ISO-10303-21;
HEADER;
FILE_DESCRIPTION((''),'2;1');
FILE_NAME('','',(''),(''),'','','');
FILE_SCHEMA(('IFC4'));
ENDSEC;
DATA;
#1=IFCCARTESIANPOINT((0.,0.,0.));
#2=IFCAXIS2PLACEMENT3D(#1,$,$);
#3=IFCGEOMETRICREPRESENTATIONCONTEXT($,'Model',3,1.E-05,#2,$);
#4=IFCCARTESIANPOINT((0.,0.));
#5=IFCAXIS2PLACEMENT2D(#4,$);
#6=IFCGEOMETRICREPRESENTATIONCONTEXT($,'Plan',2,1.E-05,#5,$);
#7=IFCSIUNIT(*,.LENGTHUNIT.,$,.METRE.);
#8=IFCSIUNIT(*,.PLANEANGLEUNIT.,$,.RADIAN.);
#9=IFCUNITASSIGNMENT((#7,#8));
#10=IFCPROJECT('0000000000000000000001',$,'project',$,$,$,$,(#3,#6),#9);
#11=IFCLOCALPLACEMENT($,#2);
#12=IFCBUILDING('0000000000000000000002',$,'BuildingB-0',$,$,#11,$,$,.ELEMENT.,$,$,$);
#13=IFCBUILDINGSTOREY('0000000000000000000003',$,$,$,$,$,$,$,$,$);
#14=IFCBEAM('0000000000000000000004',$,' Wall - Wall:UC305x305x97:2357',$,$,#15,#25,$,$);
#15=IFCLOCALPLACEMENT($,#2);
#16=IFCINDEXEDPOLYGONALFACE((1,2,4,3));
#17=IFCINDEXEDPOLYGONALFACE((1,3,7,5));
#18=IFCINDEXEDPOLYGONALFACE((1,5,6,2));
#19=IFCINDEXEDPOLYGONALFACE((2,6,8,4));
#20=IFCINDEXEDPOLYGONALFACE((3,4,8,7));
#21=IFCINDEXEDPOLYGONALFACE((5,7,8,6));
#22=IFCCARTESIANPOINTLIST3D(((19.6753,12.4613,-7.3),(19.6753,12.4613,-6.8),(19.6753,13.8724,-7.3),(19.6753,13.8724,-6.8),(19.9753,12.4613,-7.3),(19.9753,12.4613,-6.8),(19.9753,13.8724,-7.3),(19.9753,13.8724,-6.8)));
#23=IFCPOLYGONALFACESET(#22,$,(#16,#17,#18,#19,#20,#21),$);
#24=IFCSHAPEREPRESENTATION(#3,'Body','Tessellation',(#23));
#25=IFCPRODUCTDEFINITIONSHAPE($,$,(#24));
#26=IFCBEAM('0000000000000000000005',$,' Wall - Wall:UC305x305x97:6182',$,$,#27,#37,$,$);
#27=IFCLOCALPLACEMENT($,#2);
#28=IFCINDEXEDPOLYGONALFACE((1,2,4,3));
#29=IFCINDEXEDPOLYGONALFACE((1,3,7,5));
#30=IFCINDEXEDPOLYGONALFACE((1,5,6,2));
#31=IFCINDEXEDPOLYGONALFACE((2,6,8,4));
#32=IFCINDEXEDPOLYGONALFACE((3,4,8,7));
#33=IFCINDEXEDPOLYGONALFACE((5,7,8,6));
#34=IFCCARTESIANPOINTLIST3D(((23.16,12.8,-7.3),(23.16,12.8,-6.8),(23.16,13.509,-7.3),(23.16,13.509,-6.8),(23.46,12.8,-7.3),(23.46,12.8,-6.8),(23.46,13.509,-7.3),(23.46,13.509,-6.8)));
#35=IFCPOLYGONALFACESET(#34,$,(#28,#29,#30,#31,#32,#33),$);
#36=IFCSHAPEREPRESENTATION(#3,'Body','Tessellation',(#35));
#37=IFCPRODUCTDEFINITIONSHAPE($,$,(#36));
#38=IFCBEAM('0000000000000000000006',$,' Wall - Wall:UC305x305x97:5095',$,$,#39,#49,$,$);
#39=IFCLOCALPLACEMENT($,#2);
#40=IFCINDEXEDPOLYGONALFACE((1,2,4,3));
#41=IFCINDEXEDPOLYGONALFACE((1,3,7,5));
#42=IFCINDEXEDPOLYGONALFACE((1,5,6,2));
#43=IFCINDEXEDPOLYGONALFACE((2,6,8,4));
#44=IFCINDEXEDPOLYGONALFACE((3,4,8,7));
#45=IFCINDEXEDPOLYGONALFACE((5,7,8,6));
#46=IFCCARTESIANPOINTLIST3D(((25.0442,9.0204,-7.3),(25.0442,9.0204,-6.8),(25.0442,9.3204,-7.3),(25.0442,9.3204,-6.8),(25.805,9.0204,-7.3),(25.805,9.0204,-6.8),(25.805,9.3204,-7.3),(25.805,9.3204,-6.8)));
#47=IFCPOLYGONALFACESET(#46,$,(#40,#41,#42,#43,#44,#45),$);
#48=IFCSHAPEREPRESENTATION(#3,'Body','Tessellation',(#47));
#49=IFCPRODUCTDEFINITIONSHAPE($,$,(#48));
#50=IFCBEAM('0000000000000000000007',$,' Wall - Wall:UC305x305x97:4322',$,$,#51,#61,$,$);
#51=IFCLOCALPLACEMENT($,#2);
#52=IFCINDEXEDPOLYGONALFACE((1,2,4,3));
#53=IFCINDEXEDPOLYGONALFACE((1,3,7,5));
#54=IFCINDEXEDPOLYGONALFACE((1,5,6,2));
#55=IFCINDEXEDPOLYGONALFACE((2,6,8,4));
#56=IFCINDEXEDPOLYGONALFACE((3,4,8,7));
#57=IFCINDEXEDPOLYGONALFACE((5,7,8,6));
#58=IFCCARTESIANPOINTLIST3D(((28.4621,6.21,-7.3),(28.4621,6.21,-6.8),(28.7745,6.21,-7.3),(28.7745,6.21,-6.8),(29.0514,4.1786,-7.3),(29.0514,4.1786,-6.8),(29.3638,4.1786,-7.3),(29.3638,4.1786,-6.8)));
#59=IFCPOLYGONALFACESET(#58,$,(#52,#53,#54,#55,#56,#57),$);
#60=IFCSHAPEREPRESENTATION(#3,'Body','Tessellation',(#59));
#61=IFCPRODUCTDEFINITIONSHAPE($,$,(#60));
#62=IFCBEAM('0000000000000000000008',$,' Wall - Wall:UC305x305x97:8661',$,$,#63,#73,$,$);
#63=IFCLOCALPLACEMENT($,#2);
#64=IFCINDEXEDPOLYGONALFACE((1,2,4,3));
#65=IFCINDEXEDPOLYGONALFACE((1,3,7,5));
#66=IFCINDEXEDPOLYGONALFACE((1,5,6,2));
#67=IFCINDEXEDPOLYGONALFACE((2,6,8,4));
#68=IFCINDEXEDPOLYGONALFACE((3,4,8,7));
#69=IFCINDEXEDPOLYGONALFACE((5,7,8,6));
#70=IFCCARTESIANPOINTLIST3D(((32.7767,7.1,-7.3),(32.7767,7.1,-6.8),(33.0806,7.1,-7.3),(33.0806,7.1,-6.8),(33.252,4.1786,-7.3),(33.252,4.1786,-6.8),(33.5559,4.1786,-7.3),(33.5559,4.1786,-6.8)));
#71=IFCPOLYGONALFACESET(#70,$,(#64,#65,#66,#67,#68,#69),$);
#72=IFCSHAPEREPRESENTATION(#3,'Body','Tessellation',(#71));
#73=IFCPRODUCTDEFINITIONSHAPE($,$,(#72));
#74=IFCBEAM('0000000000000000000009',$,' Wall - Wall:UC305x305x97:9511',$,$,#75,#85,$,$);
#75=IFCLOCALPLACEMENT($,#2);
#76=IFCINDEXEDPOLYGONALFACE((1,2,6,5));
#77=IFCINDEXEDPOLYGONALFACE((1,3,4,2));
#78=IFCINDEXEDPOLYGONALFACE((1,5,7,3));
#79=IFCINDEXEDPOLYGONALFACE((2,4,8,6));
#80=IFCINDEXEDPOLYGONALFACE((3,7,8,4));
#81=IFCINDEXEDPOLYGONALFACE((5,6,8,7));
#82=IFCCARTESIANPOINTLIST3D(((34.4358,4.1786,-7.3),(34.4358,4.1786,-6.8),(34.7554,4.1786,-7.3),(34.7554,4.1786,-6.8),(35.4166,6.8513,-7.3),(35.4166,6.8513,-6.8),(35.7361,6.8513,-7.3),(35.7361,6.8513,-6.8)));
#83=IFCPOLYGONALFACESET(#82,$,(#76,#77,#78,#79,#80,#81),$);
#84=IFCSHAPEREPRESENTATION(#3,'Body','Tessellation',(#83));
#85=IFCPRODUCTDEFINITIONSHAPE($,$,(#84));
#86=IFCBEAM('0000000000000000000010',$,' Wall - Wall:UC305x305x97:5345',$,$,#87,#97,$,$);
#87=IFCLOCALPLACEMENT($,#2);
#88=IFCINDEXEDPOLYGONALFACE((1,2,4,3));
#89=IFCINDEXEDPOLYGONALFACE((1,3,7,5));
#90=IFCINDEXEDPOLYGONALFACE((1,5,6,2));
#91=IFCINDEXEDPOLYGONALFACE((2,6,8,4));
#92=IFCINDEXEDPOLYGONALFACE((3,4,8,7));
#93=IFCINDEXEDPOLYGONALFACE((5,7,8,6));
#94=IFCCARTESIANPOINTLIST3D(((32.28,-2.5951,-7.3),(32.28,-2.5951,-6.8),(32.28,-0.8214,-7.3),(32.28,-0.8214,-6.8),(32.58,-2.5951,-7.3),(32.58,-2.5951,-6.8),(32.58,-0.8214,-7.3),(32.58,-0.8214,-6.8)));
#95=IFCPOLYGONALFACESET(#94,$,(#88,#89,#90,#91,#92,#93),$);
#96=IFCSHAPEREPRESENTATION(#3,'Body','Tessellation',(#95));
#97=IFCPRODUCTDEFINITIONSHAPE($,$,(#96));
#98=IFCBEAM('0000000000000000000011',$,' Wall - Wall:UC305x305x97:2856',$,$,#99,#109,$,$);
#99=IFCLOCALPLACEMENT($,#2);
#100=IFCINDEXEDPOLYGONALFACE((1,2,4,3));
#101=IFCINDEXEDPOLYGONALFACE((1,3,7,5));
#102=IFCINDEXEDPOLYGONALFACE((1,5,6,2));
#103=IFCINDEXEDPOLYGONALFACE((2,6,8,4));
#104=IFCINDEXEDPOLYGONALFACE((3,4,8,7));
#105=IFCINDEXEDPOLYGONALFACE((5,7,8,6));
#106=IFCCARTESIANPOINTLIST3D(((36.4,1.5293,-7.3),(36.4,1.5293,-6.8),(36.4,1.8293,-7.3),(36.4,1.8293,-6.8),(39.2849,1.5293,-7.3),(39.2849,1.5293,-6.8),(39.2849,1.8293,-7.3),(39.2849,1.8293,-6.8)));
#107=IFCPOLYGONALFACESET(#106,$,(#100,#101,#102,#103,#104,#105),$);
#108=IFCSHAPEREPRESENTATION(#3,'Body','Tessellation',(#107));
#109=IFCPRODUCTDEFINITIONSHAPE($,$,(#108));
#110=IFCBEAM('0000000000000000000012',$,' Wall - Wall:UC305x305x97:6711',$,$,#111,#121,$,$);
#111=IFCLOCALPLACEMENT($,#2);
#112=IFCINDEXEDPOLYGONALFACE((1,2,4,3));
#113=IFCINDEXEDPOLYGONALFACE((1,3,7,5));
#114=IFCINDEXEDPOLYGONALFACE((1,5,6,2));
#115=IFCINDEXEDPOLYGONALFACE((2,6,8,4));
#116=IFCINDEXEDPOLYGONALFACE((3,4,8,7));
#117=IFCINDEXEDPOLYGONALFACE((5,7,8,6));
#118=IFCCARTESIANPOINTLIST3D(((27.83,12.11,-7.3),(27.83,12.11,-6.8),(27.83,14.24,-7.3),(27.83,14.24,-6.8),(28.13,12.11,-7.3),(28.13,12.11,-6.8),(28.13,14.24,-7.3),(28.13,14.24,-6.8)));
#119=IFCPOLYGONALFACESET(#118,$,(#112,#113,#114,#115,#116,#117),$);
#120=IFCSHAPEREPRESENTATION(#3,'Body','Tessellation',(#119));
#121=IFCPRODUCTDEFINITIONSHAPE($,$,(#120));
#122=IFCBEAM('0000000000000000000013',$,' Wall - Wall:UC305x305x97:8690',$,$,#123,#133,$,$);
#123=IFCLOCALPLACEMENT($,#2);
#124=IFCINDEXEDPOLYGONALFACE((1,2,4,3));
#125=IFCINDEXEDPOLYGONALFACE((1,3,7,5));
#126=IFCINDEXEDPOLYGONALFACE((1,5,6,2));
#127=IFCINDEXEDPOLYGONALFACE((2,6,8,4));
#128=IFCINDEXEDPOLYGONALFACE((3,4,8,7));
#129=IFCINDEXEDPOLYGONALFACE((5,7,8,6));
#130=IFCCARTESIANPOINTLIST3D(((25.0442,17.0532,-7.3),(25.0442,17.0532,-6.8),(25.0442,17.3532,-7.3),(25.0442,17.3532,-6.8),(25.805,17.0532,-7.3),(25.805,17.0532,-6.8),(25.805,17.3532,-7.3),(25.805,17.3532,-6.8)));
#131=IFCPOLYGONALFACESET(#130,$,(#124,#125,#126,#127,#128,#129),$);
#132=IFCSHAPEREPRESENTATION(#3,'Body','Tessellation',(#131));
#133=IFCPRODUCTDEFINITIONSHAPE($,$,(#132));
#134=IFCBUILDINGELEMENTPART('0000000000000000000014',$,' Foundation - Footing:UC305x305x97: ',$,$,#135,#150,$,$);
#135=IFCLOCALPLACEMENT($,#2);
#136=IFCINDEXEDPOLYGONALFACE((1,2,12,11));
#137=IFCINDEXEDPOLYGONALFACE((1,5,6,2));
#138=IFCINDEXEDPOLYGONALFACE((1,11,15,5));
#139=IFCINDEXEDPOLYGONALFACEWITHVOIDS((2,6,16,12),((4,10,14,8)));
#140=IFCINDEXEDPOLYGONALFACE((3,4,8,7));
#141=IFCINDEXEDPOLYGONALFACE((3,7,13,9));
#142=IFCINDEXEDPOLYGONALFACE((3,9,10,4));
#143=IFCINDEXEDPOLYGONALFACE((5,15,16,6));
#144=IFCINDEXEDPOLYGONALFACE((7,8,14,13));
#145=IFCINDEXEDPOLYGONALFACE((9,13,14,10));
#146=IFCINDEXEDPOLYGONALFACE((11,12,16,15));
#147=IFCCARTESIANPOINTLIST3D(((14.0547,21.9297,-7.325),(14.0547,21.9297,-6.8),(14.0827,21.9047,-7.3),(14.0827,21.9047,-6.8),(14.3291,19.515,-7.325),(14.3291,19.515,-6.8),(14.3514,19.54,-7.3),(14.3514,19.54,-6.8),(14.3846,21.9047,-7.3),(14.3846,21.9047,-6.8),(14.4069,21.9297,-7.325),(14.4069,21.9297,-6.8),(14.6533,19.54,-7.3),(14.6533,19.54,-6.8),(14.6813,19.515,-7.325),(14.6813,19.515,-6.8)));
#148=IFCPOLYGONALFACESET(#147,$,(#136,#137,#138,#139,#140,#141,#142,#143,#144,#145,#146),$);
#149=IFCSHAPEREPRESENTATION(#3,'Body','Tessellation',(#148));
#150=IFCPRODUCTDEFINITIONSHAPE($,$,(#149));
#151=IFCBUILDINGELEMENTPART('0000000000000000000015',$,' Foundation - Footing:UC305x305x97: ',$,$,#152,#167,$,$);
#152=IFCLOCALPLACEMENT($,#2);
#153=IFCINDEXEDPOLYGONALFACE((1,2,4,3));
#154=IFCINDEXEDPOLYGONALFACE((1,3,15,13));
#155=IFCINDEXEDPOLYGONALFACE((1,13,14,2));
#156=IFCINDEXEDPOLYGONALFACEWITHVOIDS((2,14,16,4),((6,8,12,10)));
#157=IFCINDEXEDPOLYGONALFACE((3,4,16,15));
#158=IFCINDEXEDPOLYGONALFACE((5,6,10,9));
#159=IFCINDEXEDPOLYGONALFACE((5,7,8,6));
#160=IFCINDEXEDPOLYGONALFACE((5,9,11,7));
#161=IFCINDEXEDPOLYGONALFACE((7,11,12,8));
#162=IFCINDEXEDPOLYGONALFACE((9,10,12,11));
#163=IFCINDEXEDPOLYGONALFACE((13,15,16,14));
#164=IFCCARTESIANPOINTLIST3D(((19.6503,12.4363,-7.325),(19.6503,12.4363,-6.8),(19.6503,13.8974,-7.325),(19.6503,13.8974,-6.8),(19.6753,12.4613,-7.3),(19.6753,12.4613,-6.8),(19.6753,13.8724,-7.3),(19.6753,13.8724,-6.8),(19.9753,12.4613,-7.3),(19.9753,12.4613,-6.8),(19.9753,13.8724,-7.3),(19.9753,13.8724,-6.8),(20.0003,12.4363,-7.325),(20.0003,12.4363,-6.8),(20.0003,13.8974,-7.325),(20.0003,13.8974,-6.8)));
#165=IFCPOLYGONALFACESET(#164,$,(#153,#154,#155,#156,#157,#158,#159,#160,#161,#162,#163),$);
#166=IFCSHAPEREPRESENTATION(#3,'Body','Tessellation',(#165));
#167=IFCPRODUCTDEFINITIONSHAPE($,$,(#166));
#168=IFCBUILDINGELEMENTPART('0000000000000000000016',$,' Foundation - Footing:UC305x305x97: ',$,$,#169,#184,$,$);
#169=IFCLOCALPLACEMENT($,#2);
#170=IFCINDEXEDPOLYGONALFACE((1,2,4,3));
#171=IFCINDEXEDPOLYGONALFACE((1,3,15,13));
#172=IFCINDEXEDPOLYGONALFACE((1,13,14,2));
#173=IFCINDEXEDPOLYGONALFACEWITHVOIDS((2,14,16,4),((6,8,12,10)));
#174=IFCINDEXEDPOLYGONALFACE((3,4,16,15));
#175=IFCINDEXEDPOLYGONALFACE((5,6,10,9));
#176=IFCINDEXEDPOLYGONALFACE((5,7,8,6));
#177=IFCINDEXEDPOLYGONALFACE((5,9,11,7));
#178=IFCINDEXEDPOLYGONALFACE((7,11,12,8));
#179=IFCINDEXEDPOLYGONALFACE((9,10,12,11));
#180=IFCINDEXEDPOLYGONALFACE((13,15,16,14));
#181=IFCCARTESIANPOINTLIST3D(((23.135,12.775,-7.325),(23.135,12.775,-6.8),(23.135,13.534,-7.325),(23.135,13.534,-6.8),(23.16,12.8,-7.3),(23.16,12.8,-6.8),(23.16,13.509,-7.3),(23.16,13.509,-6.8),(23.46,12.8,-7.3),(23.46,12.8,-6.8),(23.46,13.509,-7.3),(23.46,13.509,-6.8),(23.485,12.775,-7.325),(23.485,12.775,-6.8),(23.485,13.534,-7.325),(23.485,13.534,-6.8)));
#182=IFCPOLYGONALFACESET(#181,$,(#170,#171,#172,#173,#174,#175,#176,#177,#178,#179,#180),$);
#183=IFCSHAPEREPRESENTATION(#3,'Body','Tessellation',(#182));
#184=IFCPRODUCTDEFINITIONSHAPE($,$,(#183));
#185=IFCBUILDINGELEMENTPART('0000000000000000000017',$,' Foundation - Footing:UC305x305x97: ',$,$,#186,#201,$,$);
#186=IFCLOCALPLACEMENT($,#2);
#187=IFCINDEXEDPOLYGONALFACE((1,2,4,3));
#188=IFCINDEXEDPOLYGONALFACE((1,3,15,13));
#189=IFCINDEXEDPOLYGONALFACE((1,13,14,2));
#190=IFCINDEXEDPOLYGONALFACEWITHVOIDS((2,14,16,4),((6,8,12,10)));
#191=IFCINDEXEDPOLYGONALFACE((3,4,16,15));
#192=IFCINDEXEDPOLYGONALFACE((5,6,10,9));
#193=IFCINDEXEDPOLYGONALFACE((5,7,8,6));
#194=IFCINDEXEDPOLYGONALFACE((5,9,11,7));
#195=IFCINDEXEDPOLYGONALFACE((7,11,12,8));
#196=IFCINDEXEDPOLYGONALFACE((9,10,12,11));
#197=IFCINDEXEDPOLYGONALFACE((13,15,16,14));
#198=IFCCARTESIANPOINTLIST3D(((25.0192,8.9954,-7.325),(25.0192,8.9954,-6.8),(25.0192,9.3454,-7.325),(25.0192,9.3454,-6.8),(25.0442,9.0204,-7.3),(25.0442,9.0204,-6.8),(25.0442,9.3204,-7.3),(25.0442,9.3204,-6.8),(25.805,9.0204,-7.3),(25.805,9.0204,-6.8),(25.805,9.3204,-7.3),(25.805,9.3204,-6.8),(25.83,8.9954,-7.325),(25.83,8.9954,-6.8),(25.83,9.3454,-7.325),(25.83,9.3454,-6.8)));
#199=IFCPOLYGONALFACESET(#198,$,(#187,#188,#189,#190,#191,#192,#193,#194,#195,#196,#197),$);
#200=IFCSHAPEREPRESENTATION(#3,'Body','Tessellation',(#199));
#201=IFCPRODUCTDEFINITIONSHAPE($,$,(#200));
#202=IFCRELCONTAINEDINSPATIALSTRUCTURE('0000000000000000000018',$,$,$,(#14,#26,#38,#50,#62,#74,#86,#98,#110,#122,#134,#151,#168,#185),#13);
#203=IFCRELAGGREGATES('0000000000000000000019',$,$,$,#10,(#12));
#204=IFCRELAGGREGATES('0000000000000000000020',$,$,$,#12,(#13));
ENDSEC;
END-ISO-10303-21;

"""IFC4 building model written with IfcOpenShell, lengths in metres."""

from ifc_helpers import new_model, si_unit, origin, origin_2d, place, context, project, spatial, polyline, outline, extrude, element, save


model = new_model("IFC4")

# Units and contexts
model_context = context("Model", 3, precision=1e-05, world=origin())
plan_context = context("Plan", 2, precision=1e-05, world=origin_2d())
ifc_project = project(units=[si_unit("LENGTHUNIT", "METRE"), si_unit("PLANEANGLEUNIT", "RADIAN")], contexts=[model_context, plan_context])

# Building, storey
building_placement = place(None, origin())
building = spatial("IfcBuilding", under=ifc_project, at=building_placement, Name="BuildingB-0", CompositionType="ELEMENT")
storey = spatial("IfcBuildingStorey", under=building)

# Beams
element("IfcBeam", 1, inside=storey, Name=" Wall - Wall:UC305x305x97:2357", context=model_context, shape_type="SweptSolid", body=[
    extrude(outline(polyline([(19.6753, 12.4613, -7.3), (19.9753, 12.4613, -7.3), (19.9753, 13.8724, -7.3), (19.6753, 13.8724, -7.3), (19.6753, 12.4613, -7.3)])), None, (0.0, 0.0, 1.0), 0.5),
])
element("IfcBeam", 2, inside=storey, Name=" Wall - Wall:UC305x305x97:6182", context=model_context, shape_type="SweptSolid", body=[
    extrude(outline(polyline([(23.16, 12.8, -7.3), (23.46, 12.8, -7.3), (23.46, 13.509, -7.3), (23.16, 13.509, -7.3), (23.16, 12.8, -7.3)])), None, (0.0, 0.0, 1.0), 0.5),
])
element("IfcBeam", 3, inside=storey, Name=" Wall - Wall:UC305x305x97:5095", context=model_context, shape_type="SweptSolid", body=[
    extrude(outline(polyline([(25.0442, 9.0204, -7.3), (25.805, 9.0204, -7.3), (25.805, 9.3204, -7.3), (25.0442, 9.3204, -7.3), (25.0442, 9.0204, -7.3)])), None, (0.0, 0.0, 1.0), 0.5),
])
element("IfcBeam", 4, inside=storey, Name=" Wall - Wall:UC305x305x97:4322", context=model_context, shape_type="SweptSolid", body=[
    extrude(outline(polyline([(29.0514, 4.1786, -7.3), (29.3638, 4.1786, -7.3), (28.7745, 6.21, -7.3), (28.4621, 6.21, -7.3), (29.0514, 4.1786, -7.3)])), None, (0.0, 0.0, 1.0), 0.5),
])
element("IfcBeam", 5, inside=storey, Name=" Wall - Wall:UC305x305x97:8661", context=model_context, shape_type="SweptSolid", body=[
    extrude(outline(polyline([(33.252, 4.1786, -7.3), (33.5559, 4.1786, -7.3), (33.0806, 7.1, -7.3), (32.7767, 7.1, -7.3), (33.252, 4.1786, -7.3)])), None, (0.0, 0.0, 1.0), 0.5),
])
element("IfcBeam", 6, inside=storey, Name=" Wall - Wall:UC305x305x97:9511", context=model_context, shape_type="SweptSolid", body=[
    extrude(outline(polyline([(34.4358, 4.1786, -7.3), (34.7554, 4.1786, -7.3), (35.7361, 6.8513, -7.3), (35.4166, 6.8513, -7.3), (34.4358, 4.1786, -7.3)])), None, (0.0, 0.0, 1.0), 0.5),
])
element("IfcBeam", 7, inside=storey, Name=" Wall - Wall:UC305x305x97:5345", context=model_context, shape_type="SweptSolid", body=[
    extrude(outline(polyline([(32.28, -2.5951, -7.3), (32.58, -2.5951, -7.3), (32.58, -0.8214, -7.3), (32.28, -0.8214, -7.3), (32.28, -2.5951, -7.3)])), None, (0.0, 0.0, 1.0), 0.5),
])
element("IfcBeam", 8, inside=storey, Name=" Wall - Wall:UC305x305x97:2856", context=model_context, shape_type="SweptSolid", body=[
    extrude(outline(polyline([(36.4, 1.5293, -7.3), (36.4, 1.8293, -7.3), (39.2849, 1.8293, -7.3), (39.2849, 1.5293, -7.3), (36.4, 1.5293, -7.3)])), None, (0.0, 0.0, 1.0), 0.5),
])
element("IfcBeam", 9, inside=storey, Name=" Wall - Wall:UC305x305x97:6711", context=model_context, shape_type="SweptSolid", body=[
    extrude(outline(polyline([(27.83, 12.11, -7.3), (28.13, 12.11, -7.3), (28.13, 14.24, -7.3), (27.83, 14.24, -7.3), (27.83, 12.11, -7.3)])), None, (0.0, 0.0, 1.0), 0.5),
])
element("IfcBeam", 10, inside=storey, Name=" Wall - Wall:UC305x305x97:8690", context=model_context, shape_type="SweptSolid", body=[
    extrude(outline(polyline([(25.0442, 17.0532, -7.3), (25.0442, 17.3532, -7.3), (25.805, 17.3532, -7.3), (25.805, 17.0532, -7.3), (25.0442, 17.0532, -7.3)])), None, (0.0, 0.0, 1.0), 0.5),
])

# Building element parts, openings
building_element_part_1 = element("IfcBuildingElementPart", 11, inside=storey, Name=" Foundation - Footing:UC305x305x97: ", context=model_context, shape_type="SweptSolid", body=[
    extrude(outline(polyline([(14.3291, 19.515, -7.325), (14.6813, 19.515, -7.325), (14.4069, 21.9297, -7.325), (14.0547, 21.9297, -7.325), (14.3291, 19.515, -7.325)])), None, (0.0, 0.0, 1.0), 0.525),
])
element("IfcOpeningElement", 12, inside=storey, cuts=building_element_part_1, context=model_context, shape_type="SweptSolid", body=[
    extrude(outline(polyline([(14.3514, 19.54, -7.3), (14.6533, 19.54, -7.3), (14.3846, 21.9047, -7.3), (14.0827, 21.9047, -7.3), (14.3514, 19.54, -7.3)])), None, (0.0, 0.0, 1.0), 0.5),
])
building_element_part_2 = element("IfcBuildingElementPart", 13, inside=storey, Name=" Foundation - Footing:UC305x305x97: ", context=model_context, shape_type="SweptSolid", body=[
    extrude(outline(polyline([(19.6503, 12.4363, -7.325), (20.0003, 12.4363, -7.325), (20.0003, 13.8974, -7.325), (19.6503, 13.8974, -7.325), (19.6503, 12.4363, -7.325)])), None, (0.0, 0.0, 1.0), 0.525),
])
element("IfcOpeningElement", 14, inside=storey, cuts=building_element_part_2, context=model_context, shape_type="SweptSolid", body=[
    extrude(outline(polyline([(19.6753, 12.4613, -7.3), (19.9753, 12.4613, -7.3), (19.9753, 13.8724, -7.3), (19.6753, 13.8724, -7.3), (19.6753, 12.4613, -7.3)])), None, (0.0, 0.0, 1.0), 0.5),
])
building_element_part_3 = element("IfcBuildingElementPart", 15, inside=storey, Name=" Foundation - Footing:UC305x305x97: ", context=model_context, shape_type="SweptSolid", body=[
    extrude(outline(polyline([(23.135, 12.775, -7.325), (23.485, 12.775, -7.325), (23.485, 13.534, -7.325), (23.135, 13.534, -7.325), (23.135, 12.775, -7.325)])), None, (0.0, 0.0, 1.0), 0.525),
])
element("IfcOpeningElement", 16, inside=storey, cuts=building_element_part_3, context=model_context, shape_type="SweptSolid", body=[
    extrude(outline(polyline([(23.16, 12.8, -7.3), (23.46, 12.8, -7.3), (23.46, 13.509, -7.3), (23.16, 13.509, -7.3), (23.16, 12.8, -7.3)])), None, (0.0, 0.0, 1.0), 0.5),
])
building_element_part_4 = element("IfcBuildingElementPart", 17, inside=storey, Name=" Foundation - Footing:UC305x305x97: ", context=model_context, shape_type="SweptSolid", body=[
    extrude(outline(polyline([(25.0192, 8.9954, -7.325), (25.83, 8.9954, -7.325), (25.83, 9.3454, -7.325), (25.0192, 9.3454, -7.325), (25.0192, 8.9954, -7.325)])), None, (0.0, 0.0, 1.0), 0.525),
])
element("IfcOpeningElement", 18, inside=storey, cuts=building_element_part_4, context=model_context, shape_type="SweptSolid", body=[
    extrude(outline(polyline([(25.0442, 9.0204, -7.3), (25.805, 9.0204, -7.3), (25.805, 9.3204, -7.3), (25.0442, 9.3204, -7.3), (25.0442, 9.0204, -7.3)])), None, (0.0, 0.0, 1.0), 0.5),
])

save(model, "model.ifc")
